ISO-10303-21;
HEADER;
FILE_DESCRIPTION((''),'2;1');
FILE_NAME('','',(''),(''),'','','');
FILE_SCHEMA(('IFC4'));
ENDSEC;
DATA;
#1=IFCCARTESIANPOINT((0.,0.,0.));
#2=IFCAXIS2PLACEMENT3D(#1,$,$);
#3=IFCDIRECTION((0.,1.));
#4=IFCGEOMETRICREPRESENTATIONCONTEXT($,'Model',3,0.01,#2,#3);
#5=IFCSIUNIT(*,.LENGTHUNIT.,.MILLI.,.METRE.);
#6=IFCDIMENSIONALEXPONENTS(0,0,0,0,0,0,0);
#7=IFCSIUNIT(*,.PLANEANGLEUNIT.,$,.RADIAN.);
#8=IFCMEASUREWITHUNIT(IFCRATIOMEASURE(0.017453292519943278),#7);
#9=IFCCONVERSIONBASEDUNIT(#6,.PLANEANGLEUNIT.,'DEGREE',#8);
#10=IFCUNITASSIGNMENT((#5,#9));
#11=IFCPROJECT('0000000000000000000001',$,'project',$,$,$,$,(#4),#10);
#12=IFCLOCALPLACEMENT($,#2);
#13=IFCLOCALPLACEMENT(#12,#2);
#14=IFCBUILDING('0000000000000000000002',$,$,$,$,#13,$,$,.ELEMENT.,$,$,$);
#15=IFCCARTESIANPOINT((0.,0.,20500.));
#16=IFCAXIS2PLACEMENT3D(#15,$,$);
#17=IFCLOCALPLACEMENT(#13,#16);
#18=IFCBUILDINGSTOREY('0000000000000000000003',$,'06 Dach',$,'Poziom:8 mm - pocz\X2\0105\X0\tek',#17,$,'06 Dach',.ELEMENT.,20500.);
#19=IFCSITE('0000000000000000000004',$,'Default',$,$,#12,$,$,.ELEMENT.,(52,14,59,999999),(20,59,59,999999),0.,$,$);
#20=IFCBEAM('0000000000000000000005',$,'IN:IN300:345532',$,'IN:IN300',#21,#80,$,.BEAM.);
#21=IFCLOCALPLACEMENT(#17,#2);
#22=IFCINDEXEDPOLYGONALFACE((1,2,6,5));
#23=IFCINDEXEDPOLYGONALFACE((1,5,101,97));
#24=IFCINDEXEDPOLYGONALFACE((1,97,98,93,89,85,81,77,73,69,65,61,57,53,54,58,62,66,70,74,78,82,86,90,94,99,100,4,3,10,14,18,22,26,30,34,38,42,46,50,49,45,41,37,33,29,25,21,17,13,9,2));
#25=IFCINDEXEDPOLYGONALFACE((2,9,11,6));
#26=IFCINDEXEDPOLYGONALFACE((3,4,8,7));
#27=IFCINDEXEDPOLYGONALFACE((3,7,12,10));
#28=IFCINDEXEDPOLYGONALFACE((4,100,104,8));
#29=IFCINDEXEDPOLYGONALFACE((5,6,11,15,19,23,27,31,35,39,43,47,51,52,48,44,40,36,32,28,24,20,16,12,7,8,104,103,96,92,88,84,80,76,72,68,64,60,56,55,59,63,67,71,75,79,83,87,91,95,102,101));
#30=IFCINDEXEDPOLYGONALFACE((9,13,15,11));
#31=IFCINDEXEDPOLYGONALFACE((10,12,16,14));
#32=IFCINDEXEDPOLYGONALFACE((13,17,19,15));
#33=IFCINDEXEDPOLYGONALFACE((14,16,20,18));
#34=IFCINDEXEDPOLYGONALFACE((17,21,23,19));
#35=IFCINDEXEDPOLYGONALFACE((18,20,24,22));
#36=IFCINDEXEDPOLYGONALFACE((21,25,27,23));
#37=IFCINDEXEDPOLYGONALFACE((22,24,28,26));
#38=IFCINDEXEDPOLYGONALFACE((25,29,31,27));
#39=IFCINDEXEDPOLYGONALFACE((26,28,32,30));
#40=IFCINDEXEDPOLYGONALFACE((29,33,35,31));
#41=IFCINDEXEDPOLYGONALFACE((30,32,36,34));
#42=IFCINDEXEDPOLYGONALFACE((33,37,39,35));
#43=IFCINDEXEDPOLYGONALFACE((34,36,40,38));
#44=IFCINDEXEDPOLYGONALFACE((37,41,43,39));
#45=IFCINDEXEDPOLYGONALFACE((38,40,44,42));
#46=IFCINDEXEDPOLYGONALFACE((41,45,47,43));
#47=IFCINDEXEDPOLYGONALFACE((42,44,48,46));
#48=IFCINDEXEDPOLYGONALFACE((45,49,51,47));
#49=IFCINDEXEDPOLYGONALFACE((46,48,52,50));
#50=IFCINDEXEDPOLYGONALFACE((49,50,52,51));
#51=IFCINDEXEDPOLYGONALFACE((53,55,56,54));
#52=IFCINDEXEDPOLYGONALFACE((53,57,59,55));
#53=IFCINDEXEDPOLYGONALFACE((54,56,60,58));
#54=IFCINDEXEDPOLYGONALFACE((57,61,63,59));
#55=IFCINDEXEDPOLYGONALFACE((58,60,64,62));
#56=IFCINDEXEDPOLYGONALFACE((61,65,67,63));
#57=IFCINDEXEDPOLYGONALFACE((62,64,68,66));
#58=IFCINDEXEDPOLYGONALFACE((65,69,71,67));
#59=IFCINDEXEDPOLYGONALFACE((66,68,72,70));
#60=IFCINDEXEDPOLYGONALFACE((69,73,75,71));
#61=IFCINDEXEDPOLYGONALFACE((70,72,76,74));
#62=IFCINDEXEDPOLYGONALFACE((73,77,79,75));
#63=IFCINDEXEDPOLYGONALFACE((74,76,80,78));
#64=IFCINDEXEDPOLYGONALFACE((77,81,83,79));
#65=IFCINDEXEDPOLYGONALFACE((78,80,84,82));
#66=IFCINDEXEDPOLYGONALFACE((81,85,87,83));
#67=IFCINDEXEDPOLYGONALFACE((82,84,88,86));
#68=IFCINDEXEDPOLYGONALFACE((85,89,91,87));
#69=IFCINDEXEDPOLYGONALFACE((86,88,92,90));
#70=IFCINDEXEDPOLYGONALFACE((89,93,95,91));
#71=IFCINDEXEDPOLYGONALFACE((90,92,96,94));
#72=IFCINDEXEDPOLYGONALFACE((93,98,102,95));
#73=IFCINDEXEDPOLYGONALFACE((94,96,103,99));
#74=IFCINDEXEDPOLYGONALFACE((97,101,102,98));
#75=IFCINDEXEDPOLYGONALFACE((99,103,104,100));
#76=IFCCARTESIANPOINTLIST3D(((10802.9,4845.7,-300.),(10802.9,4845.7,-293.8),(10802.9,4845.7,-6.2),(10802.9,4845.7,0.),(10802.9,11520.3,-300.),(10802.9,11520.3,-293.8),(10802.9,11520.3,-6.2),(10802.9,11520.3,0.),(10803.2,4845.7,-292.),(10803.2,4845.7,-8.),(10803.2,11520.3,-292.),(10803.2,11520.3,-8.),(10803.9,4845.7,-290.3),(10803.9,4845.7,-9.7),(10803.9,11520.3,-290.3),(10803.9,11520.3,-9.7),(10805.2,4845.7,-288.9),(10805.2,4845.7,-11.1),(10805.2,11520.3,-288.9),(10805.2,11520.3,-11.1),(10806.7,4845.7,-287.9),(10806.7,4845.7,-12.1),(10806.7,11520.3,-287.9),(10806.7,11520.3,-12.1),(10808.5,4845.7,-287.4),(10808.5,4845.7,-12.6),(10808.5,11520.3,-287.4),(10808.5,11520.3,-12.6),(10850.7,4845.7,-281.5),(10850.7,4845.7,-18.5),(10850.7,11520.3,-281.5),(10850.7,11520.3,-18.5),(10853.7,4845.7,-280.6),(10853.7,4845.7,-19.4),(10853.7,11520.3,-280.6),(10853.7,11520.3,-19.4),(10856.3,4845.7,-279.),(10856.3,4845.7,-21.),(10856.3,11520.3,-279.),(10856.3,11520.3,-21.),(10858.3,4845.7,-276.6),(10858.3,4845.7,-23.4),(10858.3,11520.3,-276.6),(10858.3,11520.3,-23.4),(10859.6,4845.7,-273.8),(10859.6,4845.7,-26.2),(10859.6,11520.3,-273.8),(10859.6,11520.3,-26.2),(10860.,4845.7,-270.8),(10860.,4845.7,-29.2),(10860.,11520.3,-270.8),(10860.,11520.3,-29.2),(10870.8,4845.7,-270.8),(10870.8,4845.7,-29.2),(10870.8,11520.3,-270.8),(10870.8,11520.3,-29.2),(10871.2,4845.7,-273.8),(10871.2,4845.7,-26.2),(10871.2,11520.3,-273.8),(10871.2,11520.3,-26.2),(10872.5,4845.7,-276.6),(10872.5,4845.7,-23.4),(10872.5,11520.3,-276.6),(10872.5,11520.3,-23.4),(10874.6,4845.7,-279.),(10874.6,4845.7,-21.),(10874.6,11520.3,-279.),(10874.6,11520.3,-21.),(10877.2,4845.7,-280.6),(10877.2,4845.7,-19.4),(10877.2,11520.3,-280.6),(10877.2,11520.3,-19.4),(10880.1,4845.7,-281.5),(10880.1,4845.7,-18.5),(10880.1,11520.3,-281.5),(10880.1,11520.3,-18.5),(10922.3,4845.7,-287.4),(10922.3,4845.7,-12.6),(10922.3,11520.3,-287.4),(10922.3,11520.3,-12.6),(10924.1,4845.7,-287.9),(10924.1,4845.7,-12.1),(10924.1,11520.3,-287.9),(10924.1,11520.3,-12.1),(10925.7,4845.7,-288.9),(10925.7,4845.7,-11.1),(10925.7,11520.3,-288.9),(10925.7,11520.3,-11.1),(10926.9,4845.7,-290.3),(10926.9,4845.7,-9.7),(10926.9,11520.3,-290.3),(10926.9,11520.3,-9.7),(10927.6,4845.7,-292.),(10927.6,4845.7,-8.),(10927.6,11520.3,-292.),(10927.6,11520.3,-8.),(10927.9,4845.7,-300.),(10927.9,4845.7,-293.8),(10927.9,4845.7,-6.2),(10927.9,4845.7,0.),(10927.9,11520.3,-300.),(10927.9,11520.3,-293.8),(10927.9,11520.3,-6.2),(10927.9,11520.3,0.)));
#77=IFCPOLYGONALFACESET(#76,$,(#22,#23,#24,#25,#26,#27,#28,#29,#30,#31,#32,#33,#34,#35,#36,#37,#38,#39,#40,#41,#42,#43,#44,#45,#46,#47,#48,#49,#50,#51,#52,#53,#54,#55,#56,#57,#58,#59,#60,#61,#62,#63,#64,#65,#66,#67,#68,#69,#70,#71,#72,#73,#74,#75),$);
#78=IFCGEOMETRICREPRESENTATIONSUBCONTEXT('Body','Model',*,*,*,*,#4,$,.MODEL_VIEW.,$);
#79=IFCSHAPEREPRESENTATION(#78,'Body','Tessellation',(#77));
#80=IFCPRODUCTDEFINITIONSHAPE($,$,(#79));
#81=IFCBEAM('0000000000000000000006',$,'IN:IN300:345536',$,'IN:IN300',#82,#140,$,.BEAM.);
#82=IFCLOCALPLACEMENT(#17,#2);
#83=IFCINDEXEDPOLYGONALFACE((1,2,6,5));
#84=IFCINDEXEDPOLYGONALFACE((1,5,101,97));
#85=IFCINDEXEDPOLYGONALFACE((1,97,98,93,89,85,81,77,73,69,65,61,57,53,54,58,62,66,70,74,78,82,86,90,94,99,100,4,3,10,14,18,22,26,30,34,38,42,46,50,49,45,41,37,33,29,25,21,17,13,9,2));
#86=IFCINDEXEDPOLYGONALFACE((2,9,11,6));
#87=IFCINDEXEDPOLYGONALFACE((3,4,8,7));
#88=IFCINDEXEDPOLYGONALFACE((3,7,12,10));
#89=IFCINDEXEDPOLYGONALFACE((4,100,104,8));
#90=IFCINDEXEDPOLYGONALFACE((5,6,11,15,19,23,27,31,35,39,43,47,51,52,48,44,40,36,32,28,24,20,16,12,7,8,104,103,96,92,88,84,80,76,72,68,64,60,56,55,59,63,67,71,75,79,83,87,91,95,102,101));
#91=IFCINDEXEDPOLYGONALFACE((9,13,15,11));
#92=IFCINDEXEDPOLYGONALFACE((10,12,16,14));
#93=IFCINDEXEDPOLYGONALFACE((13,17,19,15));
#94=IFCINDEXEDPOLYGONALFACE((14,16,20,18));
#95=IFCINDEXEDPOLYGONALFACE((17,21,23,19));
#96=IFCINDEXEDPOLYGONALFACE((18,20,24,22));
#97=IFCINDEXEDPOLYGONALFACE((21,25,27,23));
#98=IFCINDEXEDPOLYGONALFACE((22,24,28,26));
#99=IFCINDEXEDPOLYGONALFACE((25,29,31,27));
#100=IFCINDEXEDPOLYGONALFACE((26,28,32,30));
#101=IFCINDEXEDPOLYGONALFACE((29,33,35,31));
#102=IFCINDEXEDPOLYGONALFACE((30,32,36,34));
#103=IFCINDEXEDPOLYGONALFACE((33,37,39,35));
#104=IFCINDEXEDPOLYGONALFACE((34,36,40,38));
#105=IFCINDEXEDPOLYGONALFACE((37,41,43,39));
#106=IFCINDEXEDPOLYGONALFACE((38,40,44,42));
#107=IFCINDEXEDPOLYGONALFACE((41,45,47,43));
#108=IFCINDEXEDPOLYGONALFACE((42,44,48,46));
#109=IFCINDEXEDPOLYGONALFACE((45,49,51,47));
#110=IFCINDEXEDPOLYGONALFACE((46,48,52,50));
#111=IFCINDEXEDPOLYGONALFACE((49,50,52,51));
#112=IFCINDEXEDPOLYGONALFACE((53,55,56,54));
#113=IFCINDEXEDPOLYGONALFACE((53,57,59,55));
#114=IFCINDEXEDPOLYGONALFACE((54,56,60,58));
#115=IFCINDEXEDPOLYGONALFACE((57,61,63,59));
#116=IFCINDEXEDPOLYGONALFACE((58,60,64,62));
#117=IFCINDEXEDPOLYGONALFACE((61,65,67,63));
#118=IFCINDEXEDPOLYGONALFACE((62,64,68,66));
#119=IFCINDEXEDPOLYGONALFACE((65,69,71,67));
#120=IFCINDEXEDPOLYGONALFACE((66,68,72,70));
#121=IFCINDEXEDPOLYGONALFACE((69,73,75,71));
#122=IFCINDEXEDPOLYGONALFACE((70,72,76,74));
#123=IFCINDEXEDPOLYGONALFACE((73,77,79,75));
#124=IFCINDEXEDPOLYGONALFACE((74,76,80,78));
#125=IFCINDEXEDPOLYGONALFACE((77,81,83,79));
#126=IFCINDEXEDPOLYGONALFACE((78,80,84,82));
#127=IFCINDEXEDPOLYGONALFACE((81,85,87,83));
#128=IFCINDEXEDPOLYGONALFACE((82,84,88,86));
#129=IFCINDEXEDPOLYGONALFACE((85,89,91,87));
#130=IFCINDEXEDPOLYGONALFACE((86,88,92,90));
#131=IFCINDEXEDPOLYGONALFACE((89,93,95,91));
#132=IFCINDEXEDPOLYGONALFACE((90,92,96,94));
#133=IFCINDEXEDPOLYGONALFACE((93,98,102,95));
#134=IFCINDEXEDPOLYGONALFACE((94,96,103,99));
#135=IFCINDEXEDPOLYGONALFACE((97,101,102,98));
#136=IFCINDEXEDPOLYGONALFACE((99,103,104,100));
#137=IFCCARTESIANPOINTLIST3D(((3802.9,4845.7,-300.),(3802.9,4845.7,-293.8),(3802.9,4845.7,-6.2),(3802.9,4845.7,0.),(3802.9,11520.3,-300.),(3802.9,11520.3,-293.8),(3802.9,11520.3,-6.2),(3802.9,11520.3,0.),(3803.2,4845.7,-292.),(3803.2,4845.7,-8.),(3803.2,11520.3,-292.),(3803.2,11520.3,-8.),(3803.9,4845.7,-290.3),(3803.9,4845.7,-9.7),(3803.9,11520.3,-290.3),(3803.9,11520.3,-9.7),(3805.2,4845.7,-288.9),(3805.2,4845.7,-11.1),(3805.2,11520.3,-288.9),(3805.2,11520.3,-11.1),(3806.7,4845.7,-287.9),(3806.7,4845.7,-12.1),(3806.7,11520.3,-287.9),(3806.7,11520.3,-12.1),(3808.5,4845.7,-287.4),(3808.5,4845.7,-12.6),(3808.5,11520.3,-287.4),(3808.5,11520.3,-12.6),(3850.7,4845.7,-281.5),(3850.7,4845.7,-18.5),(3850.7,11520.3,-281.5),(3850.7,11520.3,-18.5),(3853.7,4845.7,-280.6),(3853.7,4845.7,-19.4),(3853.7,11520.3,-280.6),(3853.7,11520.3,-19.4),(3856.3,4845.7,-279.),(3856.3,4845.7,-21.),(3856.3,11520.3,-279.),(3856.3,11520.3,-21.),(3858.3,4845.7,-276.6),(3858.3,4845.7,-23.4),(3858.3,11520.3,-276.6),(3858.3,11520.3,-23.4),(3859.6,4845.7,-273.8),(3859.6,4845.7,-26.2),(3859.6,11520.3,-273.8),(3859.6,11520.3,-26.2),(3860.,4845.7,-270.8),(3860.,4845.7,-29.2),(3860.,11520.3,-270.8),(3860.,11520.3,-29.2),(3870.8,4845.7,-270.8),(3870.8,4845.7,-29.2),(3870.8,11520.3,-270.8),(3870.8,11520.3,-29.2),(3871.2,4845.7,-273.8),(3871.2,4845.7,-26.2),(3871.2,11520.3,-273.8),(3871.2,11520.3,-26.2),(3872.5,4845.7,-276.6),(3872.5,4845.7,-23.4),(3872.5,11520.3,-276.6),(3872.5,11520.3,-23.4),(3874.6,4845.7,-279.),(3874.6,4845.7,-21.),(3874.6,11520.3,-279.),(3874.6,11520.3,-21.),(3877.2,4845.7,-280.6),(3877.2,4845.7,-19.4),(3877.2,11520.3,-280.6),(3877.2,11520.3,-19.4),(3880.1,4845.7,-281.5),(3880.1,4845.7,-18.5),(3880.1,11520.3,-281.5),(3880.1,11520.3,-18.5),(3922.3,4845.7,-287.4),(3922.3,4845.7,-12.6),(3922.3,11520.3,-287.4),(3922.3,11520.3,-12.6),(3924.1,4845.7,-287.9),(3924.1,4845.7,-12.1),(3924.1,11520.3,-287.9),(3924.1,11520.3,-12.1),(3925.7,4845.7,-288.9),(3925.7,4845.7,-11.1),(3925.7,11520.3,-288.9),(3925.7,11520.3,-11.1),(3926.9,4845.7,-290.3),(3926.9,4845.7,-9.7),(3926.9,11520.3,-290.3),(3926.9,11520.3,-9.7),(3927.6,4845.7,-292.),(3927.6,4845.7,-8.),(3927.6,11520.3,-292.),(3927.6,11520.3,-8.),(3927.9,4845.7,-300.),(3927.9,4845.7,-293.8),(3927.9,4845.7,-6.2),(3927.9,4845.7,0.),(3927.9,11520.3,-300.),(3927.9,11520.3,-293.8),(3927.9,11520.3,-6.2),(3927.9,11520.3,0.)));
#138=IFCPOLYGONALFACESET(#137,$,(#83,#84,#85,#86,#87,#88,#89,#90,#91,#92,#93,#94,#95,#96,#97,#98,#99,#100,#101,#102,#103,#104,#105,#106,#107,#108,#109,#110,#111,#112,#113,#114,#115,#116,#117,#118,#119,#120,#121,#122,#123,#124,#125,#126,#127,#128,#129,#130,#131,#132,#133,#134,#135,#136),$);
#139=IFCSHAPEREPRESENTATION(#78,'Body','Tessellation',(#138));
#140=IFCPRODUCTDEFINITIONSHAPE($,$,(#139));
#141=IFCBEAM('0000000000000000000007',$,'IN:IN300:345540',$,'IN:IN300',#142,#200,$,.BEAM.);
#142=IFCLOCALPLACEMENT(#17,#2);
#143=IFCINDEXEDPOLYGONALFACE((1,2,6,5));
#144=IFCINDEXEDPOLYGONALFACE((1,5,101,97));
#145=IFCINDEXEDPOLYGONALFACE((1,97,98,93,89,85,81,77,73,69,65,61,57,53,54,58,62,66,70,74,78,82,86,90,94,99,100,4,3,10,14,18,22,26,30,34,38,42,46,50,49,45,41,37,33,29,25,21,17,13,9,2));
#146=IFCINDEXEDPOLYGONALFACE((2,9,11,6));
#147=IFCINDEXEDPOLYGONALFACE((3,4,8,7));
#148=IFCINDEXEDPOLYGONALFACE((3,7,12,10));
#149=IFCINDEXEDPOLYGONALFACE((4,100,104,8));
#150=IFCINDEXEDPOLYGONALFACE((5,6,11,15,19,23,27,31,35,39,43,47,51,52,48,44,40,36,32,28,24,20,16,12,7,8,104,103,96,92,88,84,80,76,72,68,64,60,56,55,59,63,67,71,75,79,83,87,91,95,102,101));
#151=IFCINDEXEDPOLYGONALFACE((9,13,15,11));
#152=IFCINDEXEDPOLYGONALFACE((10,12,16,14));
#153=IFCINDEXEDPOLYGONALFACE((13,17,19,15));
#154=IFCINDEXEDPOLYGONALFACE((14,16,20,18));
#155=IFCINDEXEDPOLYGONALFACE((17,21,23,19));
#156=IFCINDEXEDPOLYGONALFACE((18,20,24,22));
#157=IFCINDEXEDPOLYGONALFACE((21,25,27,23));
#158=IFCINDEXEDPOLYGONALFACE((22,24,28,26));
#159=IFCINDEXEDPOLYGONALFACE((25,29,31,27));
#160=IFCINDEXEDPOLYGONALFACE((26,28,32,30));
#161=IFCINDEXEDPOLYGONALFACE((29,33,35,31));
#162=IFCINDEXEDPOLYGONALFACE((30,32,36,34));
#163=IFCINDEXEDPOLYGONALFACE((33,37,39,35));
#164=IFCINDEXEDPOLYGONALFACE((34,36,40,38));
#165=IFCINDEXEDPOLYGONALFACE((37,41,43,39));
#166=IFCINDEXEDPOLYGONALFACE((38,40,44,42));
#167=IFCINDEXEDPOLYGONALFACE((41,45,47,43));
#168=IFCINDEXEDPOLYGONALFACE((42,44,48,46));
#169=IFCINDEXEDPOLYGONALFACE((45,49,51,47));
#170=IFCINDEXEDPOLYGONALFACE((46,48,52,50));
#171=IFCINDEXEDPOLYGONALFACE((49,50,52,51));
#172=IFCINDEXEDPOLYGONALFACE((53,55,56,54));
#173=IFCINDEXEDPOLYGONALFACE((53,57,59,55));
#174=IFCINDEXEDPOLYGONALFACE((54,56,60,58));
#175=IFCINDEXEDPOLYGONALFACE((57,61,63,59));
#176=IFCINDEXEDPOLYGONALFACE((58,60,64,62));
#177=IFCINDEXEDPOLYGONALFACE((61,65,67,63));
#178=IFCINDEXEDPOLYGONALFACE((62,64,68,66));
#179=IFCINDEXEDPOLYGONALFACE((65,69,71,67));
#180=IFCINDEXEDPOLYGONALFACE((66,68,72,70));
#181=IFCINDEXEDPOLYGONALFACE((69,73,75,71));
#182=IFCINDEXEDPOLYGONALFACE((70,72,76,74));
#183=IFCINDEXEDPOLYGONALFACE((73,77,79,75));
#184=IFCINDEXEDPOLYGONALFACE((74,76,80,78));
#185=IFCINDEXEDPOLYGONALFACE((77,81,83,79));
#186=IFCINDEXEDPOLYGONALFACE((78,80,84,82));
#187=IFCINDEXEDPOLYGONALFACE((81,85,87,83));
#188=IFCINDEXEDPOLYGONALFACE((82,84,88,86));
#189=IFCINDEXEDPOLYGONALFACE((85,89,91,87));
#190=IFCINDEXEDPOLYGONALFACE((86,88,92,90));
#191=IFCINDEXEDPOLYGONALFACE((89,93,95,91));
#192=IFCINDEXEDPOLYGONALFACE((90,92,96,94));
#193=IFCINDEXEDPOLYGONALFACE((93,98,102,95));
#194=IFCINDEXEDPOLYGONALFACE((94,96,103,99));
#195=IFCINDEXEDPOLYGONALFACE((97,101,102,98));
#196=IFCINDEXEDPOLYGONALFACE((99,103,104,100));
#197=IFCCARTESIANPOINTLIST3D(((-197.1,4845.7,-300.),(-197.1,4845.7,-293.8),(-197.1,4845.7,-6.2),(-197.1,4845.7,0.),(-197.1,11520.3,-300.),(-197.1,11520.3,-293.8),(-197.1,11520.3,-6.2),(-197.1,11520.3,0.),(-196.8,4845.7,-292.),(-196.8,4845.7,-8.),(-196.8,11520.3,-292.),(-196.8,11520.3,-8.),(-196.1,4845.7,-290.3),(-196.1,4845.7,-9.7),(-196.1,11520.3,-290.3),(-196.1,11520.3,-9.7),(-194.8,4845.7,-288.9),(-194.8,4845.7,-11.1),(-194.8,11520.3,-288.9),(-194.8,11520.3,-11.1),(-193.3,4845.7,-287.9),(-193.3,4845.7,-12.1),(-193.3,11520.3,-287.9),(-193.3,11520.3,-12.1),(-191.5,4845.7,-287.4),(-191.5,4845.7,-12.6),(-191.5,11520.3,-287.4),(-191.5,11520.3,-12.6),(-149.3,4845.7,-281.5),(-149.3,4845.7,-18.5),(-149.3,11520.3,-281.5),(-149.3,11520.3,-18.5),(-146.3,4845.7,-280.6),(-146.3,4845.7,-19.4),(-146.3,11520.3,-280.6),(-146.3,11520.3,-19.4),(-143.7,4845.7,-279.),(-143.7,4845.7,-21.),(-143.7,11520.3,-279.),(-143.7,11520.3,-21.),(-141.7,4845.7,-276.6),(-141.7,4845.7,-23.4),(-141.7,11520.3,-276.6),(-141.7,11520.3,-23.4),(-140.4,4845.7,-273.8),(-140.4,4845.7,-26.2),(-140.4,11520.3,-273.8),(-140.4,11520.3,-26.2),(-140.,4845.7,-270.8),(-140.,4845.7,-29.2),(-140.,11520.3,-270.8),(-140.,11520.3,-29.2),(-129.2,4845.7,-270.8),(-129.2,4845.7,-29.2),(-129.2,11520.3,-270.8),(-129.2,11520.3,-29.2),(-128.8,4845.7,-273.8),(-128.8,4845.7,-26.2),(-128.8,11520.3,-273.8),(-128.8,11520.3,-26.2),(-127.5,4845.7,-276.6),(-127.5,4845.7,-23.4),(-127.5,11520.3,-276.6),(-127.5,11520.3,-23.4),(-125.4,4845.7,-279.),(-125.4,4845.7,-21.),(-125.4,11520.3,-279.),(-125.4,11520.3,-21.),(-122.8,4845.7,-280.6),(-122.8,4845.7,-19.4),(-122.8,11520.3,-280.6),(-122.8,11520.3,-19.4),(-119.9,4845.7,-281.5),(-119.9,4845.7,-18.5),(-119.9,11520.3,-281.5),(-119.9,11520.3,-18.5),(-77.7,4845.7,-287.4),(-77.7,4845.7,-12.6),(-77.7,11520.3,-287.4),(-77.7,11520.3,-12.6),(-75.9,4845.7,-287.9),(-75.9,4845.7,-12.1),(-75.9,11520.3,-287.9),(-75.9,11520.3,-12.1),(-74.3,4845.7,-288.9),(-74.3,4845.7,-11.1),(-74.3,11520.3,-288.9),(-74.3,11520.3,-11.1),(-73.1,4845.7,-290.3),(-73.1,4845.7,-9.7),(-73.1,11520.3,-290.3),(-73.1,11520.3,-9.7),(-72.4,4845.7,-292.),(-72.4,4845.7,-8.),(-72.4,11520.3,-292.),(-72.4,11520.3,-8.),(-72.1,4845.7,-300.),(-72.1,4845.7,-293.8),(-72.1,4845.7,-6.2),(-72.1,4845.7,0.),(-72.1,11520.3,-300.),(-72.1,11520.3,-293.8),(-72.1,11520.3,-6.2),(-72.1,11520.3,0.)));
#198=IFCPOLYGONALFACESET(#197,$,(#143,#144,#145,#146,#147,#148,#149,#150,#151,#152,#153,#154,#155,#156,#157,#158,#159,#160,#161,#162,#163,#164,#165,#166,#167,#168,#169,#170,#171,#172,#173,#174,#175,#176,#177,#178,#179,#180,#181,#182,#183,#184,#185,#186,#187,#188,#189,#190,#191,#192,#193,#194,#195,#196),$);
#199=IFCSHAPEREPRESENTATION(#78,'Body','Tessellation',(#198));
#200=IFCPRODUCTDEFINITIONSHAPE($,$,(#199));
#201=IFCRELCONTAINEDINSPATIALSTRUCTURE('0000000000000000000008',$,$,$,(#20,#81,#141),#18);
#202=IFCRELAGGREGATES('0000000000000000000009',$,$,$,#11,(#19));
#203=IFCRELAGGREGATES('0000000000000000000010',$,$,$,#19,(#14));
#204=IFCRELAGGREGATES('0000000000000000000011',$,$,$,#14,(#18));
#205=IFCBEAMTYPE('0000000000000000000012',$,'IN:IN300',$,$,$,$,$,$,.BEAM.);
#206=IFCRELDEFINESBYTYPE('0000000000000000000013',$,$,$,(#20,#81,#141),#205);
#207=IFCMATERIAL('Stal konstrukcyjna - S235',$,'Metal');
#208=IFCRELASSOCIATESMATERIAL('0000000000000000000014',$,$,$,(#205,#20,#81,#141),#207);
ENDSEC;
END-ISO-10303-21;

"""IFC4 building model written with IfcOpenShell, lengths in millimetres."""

from ifc_helpers import new_model, entity, si_unit, converted_unit, direction, frame, origin, place, context, subcontext, project, spatial, line, arc, indexed_curve, outline, extrude, source, transform, mapped, material, type_object, type_shapes, element, save


model = new_model("IFC4")

# Units and contexts
model_context = context("Model", 3, precision=0.01, world=origin(), true_north=direction((0.0, 1.0)))
body_context = subcontext(model_context, "Body", "Model", "MODEL_VIEW")
ifc_project = project(units=[si_unit("LENGTHUNIT", "METRE", prefix="MILLI"), converted_unit("PLANEANGLEUNIT", "DEGREE", entity("IfcRatioMeasure", 0.017453292519943278), si_unit("PLANEANGLEUNIT", "RADIAN"), dimensions=[0, 0, 0, 0, 0, 0, 0])], contexts=[model_context])

# Site, building, storey
site_placement = place(None, origin())
site = spatial("IfcSite", under=ifc_project, at=site_placement, Name="Default", CompositionType="ELEMENT", RefLatitude=(52, 14, 59, 999999), RefLongitude=(20, 59, 59, 999999), RefElevation=0.0)
building_placement = place(site_placement, origin())
building = spatial("IfcBuilding", under=site, at=building_placement, CompositionType="ELEMENT")
storey_placement = place(building_placement, frame((0.0, 0.0, 20500.0)))
storey = spatial("IfcBuildingStorey", under=building, at=storey_placement, Name="06 Dach", ObjectType="Poziom:8 mm - początek", LongName="06 Dach", CompositionType="ELEMENT", Elevation=20500.0)

# Beams
ifc_material = material(Name="Stal konstrukcyjna - S235", Category="Metal")
beam_type_1 = type_object("IfcBeamType", Name="IN:IN300", PredefinedType="BEAM", material=ifc_material)
shared_shape_1 = source(origin(), body_context, "Body", "SweptSolid", [
    extrude(outline(indexed_curve([(143.8, -62.5), (150.0, -62.5), (150.0, 62.5), (143.8, 62.5), (139.6, 60.9), (137.4, 56.9), (131.5, 14.7), (127.9, 8.1), (120.8, 5.4), (-120.8, 5.4), (-127.9, 8.1), (-131.5, 14.7), (-137.4, 56.9), (-139.6, 60.9), (-143.8, 62.5), (-150.0, 62.5), (-150.0, -62.5), (-143.8, -62.5), (-139.6, -60.9), (-137.4, -56.9), (-131.5, -14.7), (-127.9, -8.1), (-120.8, -5.4), (120.8, -5.4), (127.9, -8.1), (131.5, -14.7), (137.4, -56.9), (139.6, -60.9)], segments=[line(1, 2, 3, 4), arc(4, 5, 6), line(6, 7), arc(7, 8, 9), line(9, 10), arc(10, 11, 12), line(12, 13), arc(13, 14, 15), line(15, 16, 17, 18), arc(18, 19, 20), line(20, 21), arc(21, 22, 23), line(23, 24), arc(24, 25, 26), line(26, 27), arc(27, 28, 1)], self_intersect=False)), frame((-3337.3, 0.0, 0.0), z_axis=(1.0, 0.0, 0.0), x_axis=(0.0, 0.0, -1.0)), (0.0, 0.0, 1.0), 6674.6),
])
type_shapes(beam_type_1, [shared_shape_1])
for number, where, z_axis, x_axis, name in (
    (1, (10865.4, 8183.0, -150.0), (0.0, 0.0, 1.0), (0.0, -1.0, 0.0), "IN:IN300:345532"),
    (2, (3865.4, 8183.0, -150.0), (0.0, 0.0, 1.0), (0.0, -1.0, 0.0), "IN:IN300:345536"),
    (3, (-134.6, 8183.0, -150.0), (0.0, 0.0, 1.0), (0.0, -1.0, 0.0), "IN:IN300:345540"),
):
    element("IfcBeam", number, at=place(storey_placement, frame(where, z_axis=z_axis, x_axis=x_axis)), inside=storey, type_object=beam_type_1, material=ifc_material, Name=name, ObjectType="IN:IN300", PredefinedType="BEAM", context=body_context, shape_type="MappedRepresentation", body=[
        mapped(shared_shape_1, transform((0.0, 0.0, 0.0), scale=1.0)),
    ])

save(model, "model.ifc")
